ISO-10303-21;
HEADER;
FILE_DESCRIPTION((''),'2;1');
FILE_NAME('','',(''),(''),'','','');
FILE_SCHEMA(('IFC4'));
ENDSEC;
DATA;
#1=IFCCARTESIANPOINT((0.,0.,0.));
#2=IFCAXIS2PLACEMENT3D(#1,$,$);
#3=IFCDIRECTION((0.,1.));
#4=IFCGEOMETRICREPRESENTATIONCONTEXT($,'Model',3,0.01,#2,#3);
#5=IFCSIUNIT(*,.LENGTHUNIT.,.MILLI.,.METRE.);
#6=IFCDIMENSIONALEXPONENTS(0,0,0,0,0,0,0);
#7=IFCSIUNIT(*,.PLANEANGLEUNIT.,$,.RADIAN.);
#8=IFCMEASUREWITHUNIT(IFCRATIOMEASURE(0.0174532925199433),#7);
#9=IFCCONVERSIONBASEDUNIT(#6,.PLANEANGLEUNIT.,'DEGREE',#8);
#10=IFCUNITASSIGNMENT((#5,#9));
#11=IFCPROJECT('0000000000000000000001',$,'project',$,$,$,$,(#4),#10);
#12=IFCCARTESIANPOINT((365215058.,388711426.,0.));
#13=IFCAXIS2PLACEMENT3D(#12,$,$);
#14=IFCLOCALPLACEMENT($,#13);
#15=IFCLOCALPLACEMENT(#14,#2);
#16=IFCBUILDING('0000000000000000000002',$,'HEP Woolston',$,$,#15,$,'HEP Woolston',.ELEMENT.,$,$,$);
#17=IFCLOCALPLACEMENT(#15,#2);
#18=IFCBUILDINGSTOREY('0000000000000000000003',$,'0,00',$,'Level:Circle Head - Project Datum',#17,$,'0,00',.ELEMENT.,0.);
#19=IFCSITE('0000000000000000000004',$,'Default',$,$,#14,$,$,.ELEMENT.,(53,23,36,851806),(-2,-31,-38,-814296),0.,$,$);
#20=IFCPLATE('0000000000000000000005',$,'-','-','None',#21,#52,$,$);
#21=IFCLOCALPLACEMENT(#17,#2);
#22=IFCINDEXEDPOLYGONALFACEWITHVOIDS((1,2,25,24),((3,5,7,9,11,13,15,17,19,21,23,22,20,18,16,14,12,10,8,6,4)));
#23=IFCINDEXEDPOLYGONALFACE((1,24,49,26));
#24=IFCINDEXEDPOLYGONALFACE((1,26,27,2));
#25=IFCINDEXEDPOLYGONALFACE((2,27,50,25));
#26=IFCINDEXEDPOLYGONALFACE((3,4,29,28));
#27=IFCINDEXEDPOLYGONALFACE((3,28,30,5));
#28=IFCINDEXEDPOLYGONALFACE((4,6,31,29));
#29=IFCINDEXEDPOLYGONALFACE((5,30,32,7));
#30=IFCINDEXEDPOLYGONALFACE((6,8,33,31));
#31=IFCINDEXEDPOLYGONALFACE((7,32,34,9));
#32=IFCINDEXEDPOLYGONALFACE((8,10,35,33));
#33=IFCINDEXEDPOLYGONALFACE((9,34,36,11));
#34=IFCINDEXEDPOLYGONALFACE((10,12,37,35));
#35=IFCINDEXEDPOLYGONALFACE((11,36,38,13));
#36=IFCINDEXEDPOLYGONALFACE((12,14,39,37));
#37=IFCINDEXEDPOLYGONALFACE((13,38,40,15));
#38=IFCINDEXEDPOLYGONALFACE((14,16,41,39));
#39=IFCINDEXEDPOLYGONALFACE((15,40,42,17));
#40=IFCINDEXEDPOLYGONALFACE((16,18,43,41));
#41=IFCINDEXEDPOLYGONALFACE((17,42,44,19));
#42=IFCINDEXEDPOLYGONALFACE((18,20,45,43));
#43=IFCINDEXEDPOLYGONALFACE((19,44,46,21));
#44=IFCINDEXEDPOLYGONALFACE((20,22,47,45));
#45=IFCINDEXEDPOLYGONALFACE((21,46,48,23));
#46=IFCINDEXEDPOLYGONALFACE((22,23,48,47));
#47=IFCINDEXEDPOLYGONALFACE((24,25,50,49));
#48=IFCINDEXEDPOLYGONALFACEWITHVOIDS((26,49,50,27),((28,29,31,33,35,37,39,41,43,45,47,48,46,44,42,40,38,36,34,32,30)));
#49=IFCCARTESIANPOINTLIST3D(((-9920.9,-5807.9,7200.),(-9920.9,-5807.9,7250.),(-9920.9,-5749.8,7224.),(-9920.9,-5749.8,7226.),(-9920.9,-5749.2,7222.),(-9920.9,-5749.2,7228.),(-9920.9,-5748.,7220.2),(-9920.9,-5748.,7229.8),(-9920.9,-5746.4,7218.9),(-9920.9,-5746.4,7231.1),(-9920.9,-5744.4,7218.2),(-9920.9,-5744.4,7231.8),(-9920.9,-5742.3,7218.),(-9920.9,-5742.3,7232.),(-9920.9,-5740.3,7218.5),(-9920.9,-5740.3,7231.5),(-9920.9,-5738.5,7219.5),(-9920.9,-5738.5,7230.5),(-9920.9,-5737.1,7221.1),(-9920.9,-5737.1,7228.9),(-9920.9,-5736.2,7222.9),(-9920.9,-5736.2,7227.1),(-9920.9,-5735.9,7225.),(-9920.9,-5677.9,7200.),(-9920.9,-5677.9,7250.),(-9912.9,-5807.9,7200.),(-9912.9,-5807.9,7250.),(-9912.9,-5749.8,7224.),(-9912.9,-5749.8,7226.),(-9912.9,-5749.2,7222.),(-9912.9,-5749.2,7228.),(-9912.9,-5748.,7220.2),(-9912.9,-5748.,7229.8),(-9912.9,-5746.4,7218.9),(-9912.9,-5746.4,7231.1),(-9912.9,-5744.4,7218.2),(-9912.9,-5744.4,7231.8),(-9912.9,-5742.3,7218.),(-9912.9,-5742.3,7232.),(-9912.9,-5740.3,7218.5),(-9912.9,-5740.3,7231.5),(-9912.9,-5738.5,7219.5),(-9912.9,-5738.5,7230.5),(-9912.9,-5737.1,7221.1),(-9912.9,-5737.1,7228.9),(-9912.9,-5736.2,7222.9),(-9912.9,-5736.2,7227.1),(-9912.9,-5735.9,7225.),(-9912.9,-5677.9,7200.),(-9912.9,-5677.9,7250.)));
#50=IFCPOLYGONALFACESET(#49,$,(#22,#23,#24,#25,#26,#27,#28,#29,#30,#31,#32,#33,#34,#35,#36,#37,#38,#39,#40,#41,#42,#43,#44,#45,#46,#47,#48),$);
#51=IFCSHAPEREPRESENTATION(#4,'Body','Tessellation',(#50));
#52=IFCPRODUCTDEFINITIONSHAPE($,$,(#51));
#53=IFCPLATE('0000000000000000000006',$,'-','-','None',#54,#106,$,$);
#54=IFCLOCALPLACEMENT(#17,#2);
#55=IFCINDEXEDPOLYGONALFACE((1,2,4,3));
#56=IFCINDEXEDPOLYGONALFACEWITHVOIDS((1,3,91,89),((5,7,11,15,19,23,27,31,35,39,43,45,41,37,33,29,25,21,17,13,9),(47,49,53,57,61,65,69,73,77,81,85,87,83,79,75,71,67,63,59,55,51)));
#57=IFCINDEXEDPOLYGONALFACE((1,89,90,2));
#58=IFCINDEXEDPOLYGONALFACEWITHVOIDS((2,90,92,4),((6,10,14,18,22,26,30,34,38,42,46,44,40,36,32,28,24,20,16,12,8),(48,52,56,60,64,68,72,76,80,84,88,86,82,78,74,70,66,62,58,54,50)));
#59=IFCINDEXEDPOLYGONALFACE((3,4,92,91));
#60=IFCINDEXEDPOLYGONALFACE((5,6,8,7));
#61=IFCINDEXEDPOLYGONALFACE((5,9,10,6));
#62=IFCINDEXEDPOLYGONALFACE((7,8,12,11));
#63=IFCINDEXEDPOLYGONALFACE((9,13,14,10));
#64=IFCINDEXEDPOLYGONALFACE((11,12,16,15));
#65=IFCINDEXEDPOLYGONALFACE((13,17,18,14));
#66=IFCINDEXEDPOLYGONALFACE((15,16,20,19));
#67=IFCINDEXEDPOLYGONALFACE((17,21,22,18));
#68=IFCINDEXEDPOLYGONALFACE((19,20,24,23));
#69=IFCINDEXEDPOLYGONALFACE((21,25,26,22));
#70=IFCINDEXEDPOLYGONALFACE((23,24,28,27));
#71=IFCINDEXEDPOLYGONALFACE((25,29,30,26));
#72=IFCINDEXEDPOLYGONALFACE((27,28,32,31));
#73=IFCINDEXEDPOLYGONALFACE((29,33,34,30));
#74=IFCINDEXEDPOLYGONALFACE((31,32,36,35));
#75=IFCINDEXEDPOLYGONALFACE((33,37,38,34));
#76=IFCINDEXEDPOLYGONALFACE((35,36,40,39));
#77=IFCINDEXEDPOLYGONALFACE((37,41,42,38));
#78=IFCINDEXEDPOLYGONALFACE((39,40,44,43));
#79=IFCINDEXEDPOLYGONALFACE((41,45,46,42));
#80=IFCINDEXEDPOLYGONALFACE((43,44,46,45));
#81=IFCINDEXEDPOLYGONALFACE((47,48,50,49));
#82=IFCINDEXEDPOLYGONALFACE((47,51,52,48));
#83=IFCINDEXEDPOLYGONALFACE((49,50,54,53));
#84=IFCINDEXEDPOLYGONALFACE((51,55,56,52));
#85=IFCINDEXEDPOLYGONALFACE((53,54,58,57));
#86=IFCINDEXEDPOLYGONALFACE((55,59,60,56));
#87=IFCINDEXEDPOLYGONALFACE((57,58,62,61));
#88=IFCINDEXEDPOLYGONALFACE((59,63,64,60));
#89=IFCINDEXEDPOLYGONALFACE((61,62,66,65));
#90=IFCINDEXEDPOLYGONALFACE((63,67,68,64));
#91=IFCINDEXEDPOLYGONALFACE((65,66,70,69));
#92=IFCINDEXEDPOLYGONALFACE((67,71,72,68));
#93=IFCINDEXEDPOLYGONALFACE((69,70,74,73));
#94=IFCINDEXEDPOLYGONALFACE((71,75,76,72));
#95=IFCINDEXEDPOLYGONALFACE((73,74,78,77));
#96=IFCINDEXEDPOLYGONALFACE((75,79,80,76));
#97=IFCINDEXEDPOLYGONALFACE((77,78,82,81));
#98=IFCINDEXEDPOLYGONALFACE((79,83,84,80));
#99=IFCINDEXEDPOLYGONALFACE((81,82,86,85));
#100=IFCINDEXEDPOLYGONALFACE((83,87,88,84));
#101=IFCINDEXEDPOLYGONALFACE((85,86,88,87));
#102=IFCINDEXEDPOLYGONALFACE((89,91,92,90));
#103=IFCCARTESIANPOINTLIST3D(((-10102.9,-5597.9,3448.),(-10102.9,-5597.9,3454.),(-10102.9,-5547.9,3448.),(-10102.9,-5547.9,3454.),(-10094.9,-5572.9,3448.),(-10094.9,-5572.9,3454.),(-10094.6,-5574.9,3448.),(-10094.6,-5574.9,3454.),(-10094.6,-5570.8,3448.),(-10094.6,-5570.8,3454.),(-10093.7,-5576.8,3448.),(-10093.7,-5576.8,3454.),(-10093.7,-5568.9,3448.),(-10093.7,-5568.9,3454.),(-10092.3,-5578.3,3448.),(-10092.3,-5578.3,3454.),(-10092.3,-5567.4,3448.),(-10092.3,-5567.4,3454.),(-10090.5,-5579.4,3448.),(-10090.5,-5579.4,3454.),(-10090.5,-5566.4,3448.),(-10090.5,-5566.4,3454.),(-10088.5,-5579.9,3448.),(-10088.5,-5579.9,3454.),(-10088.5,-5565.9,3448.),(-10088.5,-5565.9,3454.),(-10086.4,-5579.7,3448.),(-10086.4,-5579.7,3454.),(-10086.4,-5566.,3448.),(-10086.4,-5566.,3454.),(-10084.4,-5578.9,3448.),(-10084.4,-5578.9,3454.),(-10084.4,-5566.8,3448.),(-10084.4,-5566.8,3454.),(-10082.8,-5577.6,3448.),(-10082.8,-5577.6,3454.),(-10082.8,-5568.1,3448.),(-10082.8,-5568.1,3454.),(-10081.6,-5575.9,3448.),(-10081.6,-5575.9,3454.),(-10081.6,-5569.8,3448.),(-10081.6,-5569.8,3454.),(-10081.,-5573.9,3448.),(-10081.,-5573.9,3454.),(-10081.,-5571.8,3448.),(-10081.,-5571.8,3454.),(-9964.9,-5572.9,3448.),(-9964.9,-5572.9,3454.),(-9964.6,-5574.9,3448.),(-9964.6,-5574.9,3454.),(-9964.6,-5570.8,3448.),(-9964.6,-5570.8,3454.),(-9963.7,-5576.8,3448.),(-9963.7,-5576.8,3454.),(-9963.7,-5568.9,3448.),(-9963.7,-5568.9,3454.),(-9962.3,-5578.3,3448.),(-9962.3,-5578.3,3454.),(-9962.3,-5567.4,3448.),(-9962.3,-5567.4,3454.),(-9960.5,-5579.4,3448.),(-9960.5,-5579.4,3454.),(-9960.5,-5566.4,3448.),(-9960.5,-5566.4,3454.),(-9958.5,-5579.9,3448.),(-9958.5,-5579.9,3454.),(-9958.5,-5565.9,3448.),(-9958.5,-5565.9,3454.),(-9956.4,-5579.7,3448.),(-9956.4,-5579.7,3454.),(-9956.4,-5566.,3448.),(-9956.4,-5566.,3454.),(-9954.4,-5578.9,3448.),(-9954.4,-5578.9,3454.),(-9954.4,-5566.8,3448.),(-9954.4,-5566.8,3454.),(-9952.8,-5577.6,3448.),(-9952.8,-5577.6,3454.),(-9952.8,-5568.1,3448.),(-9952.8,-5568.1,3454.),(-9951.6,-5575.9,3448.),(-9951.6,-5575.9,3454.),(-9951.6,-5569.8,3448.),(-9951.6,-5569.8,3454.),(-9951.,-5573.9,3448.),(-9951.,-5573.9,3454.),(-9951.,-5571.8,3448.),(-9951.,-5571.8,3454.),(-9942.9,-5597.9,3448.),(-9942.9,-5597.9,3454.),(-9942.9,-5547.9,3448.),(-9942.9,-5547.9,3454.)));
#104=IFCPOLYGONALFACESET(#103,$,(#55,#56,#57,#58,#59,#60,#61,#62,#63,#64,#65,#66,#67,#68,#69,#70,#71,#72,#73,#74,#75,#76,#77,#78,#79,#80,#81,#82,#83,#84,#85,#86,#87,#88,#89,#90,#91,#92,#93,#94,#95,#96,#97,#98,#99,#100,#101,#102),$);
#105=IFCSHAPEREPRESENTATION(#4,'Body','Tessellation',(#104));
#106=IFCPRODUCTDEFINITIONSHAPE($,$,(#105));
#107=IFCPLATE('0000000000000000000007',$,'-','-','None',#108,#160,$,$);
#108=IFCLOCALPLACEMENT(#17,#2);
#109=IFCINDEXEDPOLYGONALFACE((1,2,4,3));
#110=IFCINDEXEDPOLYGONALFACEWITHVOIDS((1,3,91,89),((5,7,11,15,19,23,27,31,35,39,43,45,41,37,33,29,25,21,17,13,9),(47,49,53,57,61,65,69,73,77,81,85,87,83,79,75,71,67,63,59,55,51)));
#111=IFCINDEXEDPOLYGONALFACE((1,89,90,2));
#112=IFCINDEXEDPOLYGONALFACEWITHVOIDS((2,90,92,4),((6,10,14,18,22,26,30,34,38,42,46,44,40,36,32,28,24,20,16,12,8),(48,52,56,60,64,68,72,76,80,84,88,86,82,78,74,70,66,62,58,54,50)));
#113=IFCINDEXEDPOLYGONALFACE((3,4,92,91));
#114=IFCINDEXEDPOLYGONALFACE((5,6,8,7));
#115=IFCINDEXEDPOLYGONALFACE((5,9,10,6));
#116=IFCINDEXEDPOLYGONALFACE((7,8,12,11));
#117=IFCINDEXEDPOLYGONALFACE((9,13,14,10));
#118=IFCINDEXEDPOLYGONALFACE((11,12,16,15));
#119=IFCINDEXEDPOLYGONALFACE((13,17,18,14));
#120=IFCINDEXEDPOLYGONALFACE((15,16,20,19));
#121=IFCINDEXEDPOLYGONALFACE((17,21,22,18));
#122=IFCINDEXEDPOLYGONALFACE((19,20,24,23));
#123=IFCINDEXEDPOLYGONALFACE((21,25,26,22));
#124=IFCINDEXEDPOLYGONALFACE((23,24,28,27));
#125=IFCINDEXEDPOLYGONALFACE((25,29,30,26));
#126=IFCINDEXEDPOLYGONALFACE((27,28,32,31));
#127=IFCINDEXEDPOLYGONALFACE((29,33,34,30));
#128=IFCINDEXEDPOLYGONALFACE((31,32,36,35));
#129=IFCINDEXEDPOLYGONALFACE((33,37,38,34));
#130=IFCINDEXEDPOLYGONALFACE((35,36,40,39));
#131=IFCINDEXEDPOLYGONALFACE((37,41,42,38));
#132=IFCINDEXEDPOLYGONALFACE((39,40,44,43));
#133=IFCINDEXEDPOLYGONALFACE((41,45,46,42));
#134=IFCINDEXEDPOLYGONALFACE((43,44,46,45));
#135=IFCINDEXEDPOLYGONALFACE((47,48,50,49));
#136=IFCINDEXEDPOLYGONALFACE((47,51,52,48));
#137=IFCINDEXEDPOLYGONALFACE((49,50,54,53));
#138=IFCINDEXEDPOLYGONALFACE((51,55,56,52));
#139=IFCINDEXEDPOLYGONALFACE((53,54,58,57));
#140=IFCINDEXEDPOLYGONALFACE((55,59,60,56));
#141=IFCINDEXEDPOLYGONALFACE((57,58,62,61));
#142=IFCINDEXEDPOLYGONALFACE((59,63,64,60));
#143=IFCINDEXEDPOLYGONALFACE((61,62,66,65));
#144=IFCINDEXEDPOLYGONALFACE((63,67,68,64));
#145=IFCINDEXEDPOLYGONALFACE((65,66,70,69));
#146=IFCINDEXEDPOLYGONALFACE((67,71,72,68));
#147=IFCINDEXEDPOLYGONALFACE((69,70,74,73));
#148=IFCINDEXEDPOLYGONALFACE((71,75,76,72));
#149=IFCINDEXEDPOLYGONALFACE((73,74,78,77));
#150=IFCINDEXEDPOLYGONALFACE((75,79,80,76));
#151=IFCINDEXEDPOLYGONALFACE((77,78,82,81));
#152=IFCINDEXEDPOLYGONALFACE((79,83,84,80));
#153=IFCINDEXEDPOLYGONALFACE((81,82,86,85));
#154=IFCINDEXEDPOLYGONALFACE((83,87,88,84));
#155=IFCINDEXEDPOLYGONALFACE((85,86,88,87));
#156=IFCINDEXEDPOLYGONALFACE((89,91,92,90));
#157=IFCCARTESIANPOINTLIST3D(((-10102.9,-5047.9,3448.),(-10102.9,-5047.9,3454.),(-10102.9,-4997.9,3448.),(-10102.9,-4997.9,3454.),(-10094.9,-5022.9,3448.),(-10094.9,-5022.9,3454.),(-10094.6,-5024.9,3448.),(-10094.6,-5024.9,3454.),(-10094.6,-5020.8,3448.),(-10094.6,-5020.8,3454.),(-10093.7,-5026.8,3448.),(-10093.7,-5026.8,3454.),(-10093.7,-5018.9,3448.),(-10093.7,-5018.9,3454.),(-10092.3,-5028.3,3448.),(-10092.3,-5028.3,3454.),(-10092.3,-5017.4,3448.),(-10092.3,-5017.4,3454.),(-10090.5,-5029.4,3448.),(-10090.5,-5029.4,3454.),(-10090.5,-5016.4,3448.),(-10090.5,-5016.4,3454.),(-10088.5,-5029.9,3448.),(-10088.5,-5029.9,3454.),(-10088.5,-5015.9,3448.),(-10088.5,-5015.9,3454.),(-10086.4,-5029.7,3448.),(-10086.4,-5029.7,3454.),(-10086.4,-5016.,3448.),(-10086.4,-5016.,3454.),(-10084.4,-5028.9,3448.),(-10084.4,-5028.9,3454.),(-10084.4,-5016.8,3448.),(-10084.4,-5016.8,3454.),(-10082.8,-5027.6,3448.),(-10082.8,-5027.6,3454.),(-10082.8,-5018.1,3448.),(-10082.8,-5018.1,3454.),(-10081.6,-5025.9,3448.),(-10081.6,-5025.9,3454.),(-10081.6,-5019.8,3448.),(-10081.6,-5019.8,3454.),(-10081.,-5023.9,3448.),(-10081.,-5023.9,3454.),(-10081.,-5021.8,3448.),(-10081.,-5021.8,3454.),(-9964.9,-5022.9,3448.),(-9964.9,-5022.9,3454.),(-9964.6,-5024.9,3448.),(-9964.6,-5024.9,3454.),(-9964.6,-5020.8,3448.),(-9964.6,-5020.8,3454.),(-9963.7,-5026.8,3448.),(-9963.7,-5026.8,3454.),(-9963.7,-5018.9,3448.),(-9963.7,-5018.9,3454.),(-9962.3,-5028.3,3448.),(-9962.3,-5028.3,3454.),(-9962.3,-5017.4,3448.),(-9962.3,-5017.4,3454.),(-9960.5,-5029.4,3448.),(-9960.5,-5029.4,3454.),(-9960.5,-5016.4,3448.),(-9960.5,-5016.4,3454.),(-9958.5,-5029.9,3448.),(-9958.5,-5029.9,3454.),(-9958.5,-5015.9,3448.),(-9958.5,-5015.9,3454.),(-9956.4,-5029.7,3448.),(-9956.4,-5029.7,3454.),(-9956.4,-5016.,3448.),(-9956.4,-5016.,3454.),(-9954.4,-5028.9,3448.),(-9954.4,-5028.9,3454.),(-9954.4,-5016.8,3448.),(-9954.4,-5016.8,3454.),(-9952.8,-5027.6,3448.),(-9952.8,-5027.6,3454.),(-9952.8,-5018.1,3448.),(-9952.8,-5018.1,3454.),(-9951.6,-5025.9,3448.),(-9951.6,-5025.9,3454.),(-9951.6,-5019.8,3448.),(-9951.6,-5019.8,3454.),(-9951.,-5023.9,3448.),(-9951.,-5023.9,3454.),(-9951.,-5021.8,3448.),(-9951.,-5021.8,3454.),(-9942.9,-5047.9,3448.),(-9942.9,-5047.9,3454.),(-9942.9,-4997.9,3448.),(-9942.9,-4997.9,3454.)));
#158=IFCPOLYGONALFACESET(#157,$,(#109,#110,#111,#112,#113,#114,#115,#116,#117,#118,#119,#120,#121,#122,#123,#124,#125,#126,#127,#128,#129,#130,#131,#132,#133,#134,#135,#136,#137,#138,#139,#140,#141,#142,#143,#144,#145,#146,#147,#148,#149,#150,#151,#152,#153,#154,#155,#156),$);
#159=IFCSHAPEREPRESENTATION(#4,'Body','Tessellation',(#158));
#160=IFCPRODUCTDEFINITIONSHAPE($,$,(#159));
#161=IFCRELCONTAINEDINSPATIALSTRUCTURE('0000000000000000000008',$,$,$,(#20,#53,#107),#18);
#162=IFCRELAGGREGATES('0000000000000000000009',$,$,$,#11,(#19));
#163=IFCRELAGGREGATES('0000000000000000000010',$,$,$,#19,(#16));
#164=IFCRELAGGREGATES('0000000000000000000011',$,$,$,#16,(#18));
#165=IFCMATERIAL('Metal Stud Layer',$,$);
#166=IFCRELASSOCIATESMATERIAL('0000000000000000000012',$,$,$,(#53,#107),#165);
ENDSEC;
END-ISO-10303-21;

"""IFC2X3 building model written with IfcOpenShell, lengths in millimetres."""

from ifc_helpers import new_model, entity, si_unit, converted_unit, direction, frame, frame_2d, origin, origin_with_axes, origin_2d_with_axis, place, context, project, spatial, polyline, circle, outline, extrude, material, element, save


model = new_model("IFC2X3")

# Units and contexts
model_context = context("Model", 3, precision=0.01, world=origin(), true_north=direction((0.0, 1.0)))
ifc_project = project(units=[si_unit("LENGTHUNIT", "METRE", prefix="MILLI"), converted_unit("PLANEANGLEUNIT", "DEGREE", entity("IfcRatioMeasure", 0.0174532925199433), si_unit("PLANEANGLEUNIT", "RADIAN"), dimensions=[0, 0, 0, 0, 0, 0, 0])], contexts=[model_context])

# Site, building, storey
site_placement = place(None, frame((365215058.0, 388711426.0, 0.0)))
site = spatial("IfcSite", under=ifc_project, at=site_placement, Name="Default", CompositionType="ELEMENT", RefLatitude=(53, 23, 36, 851806), RefLongitude=(-2, -31, -38, -814296), RefElevation=0.0)
building_placement = place(site_placement, origin())
building = spatial("IfcBuilding", under=site, at=building_placement, Name="HEP Woolston", LongName="HEP Woolston", CompositionType="ELEMENT")
storey_placement = place(building_placement, origin())
storey = spatial("IfcBuildingStorey", under=building, at=storey_placement, Name="0,00", ObjectType="Level:Circle Head - Project Datum", LongName="0,00", CompositionType="ELEMENT", Elevation=0.0)

# Plate, opening
plate_1_placement = place(storey_placement, frame((-9920.9, -5807.9, 7250.0), z_axis=(1.0, 0.0, 0.0), x_axis=(0.0, 1.0, 0.0)))
plate_1 = element("IfcPlate", 1, at=plate_1_placement, inside=storey, Name="-", Description="-", ObjectType="None", context=model_context, shape_type="SweptSolid", body=[
    extrude(outline(polyline([(0.0, -50.0), (130.0, -50.0), (130.0, 0.0), (0.0, 0.0), (0.0, -50.0)])), origin_with_axes(), (0.0, 0.0, 1.0), 8.0),
])
opening_1_placement = place(plate_1_placement, frame((65.0, -25.0, 8.5), z_axis=(0.0, 0.0, -1.0), x_axis=(1.0, 0.0, 0.0)))
element("IfcOpeningElement", 2, at=opening_1_placement, cuts=plate_1, ObjectType="Opening", context=model_context, shape_type="SweptSolid", body=[
    extrude(circle(Radius=7.0, at=origin_2d_with_axis()), origin(), (0.0, 0.0, 1.0), 9.0),
])

# Plates, openings
ifc_material = material(Name="Metal Stud Layer")
plate_2_placement = place(storey_placement, frame((-9942.9, -5597.9, 3454.0), z_axis=(0.0, 0.0, -1.0), x_axis=(-1.0, 0.0, 0.0)))
plate_2 = element("IfcPlate", 3, at=plate_2_placement, inside=storey, material=ifc_material, Name="-", Description="-", ObjectType="None", context=model_context, shape_type="SweptSolid", body=[
    extrude(outline(polyline([(160.0, 0.0), (160.0, 50.0), (0.0, 50.0), (0.0, 0.0), (160.0, 0.0)])), origin_with_axes(), (0.0, 0.0, 1.0), 6.0),
])
opening_2_placement = place(plate_2_placement, frame((80.0, 25.0, 6.5), z_axis=(0.0, 0.0, -1.0), x_axis=(1.0, 0.0, 0.0)))
element("IfcOpeningElement", 4, at=opening_2_placement, cuts=plate_2, ObjectType="Opening", context=model_context, shape_type="SweptSolid", body=[
    extrude(circle(Radius=7.0, at=frame_2d((65.0, 0.0), x_axis=(1.0, 0.0))), origin(), (0.0, 0.0, 1.0), 7.0),
])
opening_3_placement = place(plate_2_placement, frame((80.0, 25.0, 6.5), z_axis=(0.0, 0.0, -1.0), x_axis=(1.0, 0.0, 0.0)))
element("IfcOpeningElement", 5, at=opening_3_placement, cuts=plate_2, ObjectType="Opening", context=model_context, shape_type="SweptSolid", body=[
    extrude(circle(Radius=7.0, at=frame_2d((-65.0, 0.0), x_axis=(1.0, 0.0))), origin(), (0.0, 0.0, 1.0), 7.0),
])
plate_3_placement = place(storey_placement, frame((-9942.9, -5047.9, 3454.0), z_axis=(0.0, 0.0, -1.0), x_axis=(-1.0, 0.0, 0.0)))
plate_3 = element("IfcPlate", 6, at=plate_3_placement, inside=storey, material=ifc_material, Name="-", Description="-", ObjectType="None", context=model_context, shape_type="SweptSolid", body=[
    extrude(outline(polyline([(160.0, 0.0), (160.0, 50.0), (0.0, 50.0), (0.0, 0.0), (160.0, 0.0)])), origin_with_axes(), (0.0, 0.0, 1.0), 6.0),
])
opening_4_placement = place(plate_3_placement, frame((80.0, 25.0, 6.5), z_axis=(0.0, 0.0, -1.0), x_axis=(1.0, 0.0, 0.0)))
element("IfcOpeningElement", 7, at=opening_4_placement, cuts=plate_3, ObjectType="Opening", context=model_context, shape_type="SweptSolid", body=[
    extrude(circle(Radius=7.0, at=frame_2d((65.0, 0.0), x_axis=(1.0, 0.0))), origin(), (0.0, 0.0, 1.0), 7.0),
])
opening_5_placement = place(plate_3_placement, frame((80.0, 25.0, 6.5), z_axis=(0.0, 0.0, -1.0), x_axis=(1.0, 0.0, 0.0)))
element("IfcOpeningElement", 8, at=opening_5_placement, cuts=plate_3, ObjectType="Opening", context=model_context, shape_type="SweptSolid", body=[
    extrude(circle(Radius=7.0, at=frame_2d((-65.0, 0.0), x_axis=(1.0, 0.0))), origin(), (0.0, 0.0, 1.0), 7.0),
])

save(model, "model.ifc")
